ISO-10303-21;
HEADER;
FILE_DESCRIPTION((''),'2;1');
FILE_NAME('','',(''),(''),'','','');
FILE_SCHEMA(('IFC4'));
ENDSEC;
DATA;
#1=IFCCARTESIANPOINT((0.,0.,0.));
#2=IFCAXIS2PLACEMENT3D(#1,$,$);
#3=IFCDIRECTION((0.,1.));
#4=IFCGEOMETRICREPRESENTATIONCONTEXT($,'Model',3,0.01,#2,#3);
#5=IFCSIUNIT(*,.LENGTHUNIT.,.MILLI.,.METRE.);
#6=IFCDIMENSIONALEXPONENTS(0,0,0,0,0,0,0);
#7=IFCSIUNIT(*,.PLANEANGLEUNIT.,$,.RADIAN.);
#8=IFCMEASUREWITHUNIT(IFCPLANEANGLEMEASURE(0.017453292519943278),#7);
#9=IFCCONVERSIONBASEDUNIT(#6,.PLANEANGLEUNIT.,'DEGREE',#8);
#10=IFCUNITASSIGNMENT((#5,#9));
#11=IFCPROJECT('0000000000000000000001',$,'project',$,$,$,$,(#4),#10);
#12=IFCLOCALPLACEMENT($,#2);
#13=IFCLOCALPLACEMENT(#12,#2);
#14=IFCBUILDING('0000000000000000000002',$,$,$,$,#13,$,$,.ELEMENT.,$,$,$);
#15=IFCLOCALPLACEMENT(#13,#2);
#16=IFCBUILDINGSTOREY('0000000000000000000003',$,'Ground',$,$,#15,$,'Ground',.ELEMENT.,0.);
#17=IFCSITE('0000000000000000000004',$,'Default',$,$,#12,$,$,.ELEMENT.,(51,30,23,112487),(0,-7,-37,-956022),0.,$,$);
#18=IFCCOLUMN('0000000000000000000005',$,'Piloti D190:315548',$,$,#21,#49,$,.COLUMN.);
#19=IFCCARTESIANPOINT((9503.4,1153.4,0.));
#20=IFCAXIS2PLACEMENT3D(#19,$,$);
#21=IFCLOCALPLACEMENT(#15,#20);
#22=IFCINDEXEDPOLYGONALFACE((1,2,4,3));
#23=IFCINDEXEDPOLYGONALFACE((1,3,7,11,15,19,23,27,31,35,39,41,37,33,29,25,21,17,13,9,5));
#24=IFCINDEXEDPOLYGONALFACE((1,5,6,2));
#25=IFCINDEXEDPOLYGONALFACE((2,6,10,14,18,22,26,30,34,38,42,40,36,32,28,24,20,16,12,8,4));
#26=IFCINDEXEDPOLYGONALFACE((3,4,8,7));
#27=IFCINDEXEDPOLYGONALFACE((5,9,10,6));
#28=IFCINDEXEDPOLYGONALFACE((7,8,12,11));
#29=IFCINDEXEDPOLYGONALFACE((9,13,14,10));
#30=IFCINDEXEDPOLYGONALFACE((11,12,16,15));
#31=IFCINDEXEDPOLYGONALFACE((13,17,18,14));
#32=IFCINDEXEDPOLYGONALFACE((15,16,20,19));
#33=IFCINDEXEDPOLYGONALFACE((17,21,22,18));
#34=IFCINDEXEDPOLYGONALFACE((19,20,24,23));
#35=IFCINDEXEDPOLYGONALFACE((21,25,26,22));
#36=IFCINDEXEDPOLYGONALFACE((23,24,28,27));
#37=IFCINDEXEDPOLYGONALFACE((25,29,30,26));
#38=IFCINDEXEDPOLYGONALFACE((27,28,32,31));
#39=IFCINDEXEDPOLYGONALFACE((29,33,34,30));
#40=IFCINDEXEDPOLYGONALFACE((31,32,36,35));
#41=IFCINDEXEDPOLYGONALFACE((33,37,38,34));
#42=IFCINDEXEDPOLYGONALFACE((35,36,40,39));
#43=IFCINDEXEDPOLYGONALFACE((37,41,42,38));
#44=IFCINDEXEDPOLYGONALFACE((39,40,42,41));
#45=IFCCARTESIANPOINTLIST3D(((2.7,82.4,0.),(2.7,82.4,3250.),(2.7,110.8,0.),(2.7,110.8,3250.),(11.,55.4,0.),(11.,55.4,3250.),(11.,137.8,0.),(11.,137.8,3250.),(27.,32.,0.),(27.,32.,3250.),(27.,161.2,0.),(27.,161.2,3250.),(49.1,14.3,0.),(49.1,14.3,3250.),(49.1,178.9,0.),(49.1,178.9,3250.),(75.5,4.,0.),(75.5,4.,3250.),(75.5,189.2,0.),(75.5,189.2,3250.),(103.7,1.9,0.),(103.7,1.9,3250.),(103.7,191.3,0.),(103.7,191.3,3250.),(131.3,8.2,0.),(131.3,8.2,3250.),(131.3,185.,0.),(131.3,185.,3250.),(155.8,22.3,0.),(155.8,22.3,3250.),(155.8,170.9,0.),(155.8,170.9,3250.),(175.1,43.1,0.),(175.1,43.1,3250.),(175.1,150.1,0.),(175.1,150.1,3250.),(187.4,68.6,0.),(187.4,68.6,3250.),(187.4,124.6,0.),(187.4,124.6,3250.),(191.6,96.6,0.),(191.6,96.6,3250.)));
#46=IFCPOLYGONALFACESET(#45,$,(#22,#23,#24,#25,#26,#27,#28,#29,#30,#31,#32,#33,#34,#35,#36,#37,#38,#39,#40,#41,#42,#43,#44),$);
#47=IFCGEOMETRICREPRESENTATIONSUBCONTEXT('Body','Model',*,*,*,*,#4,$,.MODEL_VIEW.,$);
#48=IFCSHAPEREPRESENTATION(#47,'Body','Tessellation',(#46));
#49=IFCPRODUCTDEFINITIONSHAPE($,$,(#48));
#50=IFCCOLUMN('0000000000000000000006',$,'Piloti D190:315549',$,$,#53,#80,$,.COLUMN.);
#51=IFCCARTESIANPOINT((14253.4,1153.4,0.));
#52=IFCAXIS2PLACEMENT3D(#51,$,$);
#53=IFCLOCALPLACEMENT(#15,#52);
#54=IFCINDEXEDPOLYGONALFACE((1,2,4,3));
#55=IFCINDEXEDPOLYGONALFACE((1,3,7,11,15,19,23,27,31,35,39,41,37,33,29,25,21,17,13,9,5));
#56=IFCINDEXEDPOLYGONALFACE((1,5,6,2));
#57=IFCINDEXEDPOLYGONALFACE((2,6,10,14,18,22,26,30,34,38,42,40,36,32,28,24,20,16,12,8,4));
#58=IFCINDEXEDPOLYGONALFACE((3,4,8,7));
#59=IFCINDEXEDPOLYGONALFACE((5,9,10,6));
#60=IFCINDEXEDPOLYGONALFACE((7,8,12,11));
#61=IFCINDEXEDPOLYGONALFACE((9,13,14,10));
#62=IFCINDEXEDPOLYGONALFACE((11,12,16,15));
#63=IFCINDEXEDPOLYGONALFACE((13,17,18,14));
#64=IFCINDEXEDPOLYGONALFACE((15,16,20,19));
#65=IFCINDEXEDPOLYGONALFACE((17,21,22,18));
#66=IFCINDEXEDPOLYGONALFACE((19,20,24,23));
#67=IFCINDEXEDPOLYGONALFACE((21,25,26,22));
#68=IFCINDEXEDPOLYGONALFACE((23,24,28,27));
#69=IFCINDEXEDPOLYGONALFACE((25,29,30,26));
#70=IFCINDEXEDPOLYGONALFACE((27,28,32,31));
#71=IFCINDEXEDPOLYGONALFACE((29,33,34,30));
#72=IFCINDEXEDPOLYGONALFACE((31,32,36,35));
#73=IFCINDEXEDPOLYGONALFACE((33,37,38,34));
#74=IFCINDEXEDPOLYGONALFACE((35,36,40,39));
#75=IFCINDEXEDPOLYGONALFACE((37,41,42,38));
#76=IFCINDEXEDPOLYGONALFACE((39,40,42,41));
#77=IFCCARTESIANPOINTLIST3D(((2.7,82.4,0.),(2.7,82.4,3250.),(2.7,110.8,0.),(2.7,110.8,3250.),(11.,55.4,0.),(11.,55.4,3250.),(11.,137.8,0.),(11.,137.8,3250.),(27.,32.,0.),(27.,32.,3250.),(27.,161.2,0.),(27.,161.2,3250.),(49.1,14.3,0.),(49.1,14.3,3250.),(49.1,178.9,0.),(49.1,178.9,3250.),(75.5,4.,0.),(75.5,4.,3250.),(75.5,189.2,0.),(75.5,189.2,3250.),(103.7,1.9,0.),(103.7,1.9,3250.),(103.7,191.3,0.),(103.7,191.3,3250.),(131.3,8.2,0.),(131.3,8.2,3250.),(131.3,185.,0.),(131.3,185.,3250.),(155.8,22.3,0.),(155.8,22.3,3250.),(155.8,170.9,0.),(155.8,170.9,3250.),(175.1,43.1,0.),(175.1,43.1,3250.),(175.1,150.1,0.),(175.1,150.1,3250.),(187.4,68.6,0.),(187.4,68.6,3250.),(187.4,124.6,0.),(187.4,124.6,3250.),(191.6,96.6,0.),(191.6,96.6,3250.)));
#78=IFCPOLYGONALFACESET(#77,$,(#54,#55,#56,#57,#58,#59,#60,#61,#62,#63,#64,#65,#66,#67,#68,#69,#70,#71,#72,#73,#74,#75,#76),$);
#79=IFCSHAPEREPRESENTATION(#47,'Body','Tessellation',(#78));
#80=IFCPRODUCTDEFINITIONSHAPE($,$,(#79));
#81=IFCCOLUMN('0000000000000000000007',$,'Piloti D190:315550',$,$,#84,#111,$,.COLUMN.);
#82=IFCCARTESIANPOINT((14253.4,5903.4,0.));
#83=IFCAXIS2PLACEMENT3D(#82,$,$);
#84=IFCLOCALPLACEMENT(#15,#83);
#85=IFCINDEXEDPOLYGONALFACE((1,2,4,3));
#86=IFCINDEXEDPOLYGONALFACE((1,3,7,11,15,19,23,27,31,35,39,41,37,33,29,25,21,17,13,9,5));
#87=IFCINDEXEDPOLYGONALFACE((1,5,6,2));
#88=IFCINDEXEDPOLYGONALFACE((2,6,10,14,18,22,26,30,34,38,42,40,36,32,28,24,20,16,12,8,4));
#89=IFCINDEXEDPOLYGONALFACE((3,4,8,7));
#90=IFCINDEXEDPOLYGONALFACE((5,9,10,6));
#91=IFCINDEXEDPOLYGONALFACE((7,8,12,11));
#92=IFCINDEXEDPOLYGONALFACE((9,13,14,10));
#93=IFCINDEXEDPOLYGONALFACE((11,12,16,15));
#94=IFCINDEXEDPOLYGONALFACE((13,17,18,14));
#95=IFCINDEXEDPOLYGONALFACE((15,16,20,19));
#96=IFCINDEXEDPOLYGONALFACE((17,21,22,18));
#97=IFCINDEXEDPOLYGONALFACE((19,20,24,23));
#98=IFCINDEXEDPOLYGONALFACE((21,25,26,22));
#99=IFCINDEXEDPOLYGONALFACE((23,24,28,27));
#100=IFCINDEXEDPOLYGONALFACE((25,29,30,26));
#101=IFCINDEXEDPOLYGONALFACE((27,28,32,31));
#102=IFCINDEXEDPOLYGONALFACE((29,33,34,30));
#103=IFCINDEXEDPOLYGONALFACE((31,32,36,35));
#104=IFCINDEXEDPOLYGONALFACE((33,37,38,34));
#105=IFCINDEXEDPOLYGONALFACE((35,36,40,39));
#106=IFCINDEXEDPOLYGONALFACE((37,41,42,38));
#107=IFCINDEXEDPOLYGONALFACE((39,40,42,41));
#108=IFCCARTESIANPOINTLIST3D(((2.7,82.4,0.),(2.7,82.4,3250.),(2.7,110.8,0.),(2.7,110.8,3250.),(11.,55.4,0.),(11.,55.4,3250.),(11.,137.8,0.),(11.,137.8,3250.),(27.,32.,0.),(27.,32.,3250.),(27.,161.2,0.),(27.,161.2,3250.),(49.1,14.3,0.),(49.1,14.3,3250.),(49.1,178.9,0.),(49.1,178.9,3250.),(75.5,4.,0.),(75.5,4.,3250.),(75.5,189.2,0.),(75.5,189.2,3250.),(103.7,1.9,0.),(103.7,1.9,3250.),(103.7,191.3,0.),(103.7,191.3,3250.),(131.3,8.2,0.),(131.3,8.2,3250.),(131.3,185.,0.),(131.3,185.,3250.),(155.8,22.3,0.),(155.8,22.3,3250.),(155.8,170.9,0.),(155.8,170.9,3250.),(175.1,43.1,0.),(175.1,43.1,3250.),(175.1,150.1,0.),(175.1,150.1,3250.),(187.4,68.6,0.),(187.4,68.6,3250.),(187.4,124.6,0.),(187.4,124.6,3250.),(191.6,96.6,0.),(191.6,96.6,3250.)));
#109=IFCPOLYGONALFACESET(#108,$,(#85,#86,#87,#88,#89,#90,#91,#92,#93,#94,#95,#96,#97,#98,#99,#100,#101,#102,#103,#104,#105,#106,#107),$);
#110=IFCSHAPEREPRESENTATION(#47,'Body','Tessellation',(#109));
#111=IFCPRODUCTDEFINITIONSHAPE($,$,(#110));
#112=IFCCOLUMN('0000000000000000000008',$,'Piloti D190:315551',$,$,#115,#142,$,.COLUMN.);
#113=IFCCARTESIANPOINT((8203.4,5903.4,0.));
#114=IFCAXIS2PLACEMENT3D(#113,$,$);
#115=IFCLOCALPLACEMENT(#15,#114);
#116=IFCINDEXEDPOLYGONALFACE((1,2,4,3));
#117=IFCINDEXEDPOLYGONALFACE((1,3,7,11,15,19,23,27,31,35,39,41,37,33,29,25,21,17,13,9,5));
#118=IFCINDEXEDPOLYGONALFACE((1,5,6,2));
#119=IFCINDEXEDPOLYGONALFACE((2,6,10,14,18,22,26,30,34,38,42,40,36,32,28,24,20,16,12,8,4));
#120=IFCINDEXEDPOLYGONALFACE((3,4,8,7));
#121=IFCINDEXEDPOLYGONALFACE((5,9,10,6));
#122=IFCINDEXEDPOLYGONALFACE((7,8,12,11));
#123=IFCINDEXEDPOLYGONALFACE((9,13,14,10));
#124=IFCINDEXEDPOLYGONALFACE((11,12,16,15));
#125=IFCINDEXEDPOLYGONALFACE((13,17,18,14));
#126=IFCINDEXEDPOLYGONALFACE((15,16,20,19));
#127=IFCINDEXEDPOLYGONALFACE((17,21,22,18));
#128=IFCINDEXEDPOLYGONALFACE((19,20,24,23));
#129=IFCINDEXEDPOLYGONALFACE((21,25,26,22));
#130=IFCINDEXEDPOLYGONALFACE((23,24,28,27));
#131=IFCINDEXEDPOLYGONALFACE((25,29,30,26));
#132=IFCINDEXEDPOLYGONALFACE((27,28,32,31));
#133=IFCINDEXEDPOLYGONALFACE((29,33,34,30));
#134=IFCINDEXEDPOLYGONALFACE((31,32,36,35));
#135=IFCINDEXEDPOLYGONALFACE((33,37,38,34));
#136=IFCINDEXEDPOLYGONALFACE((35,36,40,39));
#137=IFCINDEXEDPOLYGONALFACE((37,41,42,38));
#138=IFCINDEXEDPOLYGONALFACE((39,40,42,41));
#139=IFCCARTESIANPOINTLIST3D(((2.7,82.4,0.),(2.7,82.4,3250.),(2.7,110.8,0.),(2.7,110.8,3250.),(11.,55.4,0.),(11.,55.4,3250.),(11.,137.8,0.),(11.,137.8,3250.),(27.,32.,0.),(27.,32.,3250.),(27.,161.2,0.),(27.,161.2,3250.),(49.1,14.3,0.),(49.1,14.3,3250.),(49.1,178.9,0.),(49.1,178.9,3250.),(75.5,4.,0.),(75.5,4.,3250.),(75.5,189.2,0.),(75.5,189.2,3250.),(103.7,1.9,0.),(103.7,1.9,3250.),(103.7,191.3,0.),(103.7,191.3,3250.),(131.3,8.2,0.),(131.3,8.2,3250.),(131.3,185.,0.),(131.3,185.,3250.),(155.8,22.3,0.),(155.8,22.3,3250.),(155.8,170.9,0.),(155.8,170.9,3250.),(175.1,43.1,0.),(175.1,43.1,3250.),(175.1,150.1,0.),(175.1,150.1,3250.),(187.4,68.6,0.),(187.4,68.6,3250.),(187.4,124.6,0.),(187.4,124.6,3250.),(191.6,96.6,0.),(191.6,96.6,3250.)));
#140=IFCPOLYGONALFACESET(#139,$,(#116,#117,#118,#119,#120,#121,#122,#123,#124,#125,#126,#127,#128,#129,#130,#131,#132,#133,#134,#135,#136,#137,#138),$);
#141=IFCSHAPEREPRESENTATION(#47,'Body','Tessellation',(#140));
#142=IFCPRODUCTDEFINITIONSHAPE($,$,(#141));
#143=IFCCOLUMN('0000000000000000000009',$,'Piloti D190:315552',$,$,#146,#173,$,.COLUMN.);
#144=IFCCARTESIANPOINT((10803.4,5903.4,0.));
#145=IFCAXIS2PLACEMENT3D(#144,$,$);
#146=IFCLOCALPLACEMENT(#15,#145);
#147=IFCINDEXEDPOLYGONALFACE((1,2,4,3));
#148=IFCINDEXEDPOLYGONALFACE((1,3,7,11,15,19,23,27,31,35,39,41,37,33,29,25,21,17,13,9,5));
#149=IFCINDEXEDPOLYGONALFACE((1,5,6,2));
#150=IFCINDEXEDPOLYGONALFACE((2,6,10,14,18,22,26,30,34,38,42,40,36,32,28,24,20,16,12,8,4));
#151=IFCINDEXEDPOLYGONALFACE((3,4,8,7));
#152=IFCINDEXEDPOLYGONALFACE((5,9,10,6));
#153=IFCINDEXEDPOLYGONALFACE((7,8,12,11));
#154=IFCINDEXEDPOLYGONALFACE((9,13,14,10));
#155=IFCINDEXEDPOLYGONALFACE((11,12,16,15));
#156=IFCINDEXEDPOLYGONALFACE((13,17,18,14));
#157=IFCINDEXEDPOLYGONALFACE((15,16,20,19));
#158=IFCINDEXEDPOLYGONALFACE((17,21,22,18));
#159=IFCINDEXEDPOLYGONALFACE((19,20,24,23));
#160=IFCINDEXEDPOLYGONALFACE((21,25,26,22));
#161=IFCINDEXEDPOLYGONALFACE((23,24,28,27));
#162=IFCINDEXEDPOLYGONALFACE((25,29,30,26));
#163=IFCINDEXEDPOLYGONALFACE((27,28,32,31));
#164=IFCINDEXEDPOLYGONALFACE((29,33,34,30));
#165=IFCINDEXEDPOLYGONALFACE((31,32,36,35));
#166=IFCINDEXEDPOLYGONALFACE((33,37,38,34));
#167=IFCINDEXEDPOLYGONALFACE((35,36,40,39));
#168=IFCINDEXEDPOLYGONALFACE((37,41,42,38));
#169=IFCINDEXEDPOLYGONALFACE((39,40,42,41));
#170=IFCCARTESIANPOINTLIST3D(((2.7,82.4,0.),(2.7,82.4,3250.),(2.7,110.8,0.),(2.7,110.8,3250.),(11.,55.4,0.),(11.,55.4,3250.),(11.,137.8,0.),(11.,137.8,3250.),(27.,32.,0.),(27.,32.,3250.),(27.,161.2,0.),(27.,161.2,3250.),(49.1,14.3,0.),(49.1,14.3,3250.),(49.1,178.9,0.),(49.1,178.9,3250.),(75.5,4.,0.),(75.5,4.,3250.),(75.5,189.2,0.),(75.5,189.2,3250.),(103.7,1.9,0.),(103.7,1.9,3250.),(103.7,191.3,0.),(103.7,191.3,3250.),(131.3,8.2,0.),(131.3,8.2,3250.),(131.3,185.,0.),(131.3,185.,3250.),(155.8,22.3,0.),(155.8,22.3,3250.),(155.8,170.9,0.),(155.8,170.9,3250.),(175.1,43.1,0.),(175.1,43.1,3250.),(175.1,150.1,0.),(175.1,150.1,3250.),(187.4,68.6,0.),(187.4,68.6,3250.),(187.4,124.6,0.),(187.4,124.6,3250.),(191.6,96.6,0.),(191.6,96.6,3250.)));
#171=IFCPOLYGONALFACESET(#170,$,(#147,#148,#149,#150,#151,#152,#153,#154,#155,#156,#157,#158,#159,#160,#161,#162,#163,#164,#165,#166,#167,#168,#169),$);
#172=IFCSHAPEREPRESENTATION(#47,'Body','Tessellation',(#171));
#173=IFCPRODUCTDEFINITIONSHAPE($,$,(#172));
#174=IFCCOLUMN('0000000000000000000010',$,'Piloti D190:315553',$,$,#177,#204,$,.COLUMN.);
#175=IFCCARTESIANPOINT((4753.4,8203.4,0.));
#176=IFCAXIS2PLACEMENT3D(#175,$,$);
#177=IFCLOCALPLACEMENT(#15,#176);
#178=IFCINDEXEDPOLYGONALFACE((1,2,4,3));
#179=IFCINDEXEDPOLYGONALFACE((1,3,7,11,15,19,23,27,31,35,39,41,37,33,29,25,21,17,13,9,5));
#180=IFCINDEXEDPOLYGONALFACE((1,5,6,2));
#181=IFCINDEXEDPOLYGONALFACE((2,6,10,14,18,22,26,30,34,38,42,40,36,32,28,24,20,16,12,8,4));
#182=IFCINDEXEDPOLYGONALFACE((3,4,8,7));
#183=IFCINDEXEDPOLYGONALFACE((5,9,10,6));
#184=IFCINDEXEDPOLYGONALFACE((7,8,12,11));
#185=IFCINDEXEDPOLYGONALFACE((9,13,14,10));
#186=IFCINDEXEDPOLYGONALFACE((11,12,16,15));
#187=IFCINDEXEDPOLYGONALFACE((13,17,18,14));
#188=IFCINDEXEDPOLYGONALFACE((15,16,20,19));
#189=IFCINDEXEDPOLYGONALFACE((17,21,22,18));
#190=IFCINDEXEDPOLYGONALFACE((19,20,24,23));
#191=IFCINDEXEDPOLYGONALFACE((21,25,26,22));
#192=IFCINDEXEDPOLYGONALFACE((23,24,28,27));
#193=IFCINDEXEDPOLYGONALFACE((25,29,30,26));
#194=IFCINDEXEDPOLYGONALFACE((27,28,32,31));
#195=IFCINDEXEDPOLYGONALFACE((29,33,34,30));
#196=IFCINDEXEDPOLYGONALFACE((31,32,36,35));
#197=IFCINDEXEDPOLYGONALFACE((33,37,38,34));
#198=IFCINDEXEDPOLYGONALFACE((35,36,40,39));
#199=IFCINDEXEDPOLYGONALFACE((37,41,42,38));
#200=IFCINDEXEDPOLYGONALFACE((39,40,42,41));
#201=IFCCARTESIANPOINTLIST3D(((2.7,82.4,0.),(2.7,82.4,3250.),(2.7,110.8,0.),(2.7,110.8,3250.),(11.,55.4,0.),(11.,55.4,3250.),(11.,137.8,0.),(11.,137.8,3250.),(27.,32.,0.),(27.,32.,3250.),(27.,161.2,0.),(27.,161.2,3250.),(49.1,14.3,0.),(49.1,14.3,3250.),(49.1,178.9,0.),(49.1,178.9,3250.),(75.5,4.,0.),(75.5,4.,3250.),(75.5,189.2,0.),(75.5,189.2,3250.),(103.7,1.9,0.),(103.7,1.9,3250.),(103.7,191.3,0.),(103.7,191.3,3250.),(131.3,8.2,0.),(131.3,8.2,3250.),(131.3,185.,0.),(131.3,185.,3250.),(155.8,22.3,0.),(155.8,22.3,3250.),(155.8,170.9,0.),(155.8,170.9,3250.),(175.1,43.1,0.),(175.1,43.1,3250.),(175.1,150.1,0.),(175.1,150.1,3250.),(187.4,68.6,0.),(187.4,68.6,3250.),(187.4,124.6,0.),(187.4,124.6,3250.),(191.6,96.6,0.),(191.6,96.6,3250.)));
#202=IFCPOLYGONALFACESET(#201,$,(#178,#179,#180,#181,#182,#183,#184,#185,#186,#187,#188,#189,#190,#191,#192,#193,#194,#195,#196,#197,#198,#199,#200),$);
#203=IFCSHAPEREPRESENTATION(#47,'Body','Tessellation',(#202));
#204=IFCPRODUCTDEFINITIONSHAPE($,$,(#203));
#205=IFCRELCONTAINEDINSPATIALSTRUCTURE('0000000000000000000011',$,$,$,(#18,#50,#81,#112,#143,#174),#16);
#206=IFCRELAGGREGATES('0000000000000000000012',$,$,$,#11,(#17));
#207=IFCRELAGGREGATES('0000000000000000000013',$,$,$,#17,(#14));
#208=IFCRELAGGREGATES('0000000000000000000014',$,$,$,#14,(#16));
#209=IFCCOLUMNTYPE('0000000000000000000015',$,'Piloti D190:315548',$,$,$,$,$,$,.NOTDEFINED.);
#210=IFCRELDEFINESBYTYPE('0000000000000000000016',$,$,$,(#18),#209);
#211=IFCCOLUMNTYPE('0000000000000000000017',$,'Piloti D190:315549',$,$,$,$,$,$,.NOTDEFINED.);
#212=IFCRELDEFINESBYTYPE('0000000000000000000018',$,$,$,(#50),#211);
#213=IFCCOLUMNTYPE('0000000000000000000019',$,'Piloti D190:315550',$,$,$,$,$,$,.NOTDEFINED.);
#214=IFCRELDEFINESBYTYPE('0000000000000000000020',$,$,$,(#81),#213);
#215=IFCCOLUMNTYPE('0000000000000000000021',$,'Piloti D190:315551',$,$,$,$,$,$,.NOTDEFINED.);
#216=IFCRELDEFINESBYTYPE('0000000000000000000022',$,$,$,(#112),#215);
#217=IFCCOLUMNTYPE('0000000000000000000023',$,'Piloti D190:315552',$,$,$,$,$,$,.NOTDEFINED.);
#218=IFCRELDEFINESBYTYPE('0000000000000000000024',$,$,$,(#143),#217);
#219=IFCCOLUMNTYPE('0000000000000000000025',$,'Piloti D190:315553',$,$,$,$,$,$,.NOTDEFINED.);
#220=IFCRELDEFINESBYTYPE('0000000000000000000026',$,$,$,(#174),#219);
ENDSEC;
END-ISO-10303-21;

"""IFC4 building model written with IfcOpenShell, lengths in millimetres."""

from ifc_helpers import new_model, entity, si_unit, converted_unit, direction, frame, origin, origin_2d_with_axis, place, context, subcontext, project, spatial, circle, extrude, type_object, element, save


model = new_model("IFC4")

# Units and contexts
model_context = context("Model", 3, precision=0.01, world=origin(), true_north=direction((0.0, 1.0)))
body_context = subcontext(model_context, "Body", "Model", "MODEL_VIEW")
ifc_project = project(units=[si_unit("LENGTHUNIT", "METRE", prefix="MILLI"), converted_unit("PLANEANGLEUNIT", "DEGREE", entity("IfcPlaneAngleMeasure", 0.017453292519943278), si_unit("PLANEANGLEUNIT", "RADIAN"), dimensions=[0, 0, 0, 0, 0, 0, 0])], contexts=[model_context])

# Site, building, storey
site_placement = place(None, origin())
site = spatial("IfcSite", under=ifc_project, at=site_placement, Name="Default", CompositionType="ELEMENT", RefLatitude=(51, 30, 23, 112487), RefLongitude=(0, -7, -37, -956022), RefElevation=0.0)
building_placement = place(site_placement, origin())
building = spatial("IfcBuilding", under=site, at=building_placement, CompositionType="ELEMENT")
storey_placement = place(building_placement, origin())
storey = spatial("IfcBuildingStorey", under=building, at=storey_placement, Name="Ground", LongName="Ground", CompositionType="ELEMENT", Elevation=0.0)

# Columns
column_type_1 = type_object("IfcColumnType", Name="Piloti D190:315548", PredefinedType="NOTDEFINED")
column_1_placement = place(storey_placement, frame((9503.4, 1153.4, 0.0)))
element("IfcColumn", 1, at=column_1_placement, inside=storey, type_object=column_type_1, Name="Piloti D190:315548", PredefinedType="COLUMN", context=body_context, shape_type="SweptSolid", body=[
    extrude(circle(Radius=95.0, at=origin_2d_with_axis()), frame((96.6, 96.6, 0.0)), (0.0, 0.0, 1.0), 3250.0),
])
column_type_2 = type_object("IfcColumnType", Name="Piloti D190:315549", PredefinedType="NOTDEFINED")
column_2_placement = place(storey_placement, frame((14253.4, 1153.4, 0.0)))
element("IfcColumn", 2, at=column_2_placement, inside=storey, type_object=column_type_2, Name="Piloti D190:315549", PredefinedType="COLUMN", context=body_context, shape_type="SweptSolid", body=[
    extrude(circle(Radius=95.0, at=origin_2d_with_axis()), frame((96.6, 96.6, 0.0)), (0.0, 0.0, 1.0), 3250.0),
])
column_type_3 = type_object("IfcColumnType", Name="Piloti D190:315550", PredefinedType="NOTDEFINED")
column_3_placement = place(storey_placement, frame((14253.4, 5903.4, 0.0)))
element("IfcColumn", 3, at=column_3_placement, inside=storey, type_object=column_type_3, Name="Piloti D190:315550", PredefinedType="COLUMN", context=body_context, shape_type="SweptSolid", body=[
    extrude(circle(Radius=95.0, at=origin_2d_with_axis()), frame((96.6, 96.6, 0.0)), (0.0, 0.0, 1.0), 3250.0),
])
column_type_4 = type_object("IfcColumnType", Name="Piloti D190:315551", PredefinedType="NOTDEFINED")
column_4_placement = place(storey_placement, frame((8203.4, 5903.4, 0.0)))
element("IfcColumn", 4, at=column_4_placement, inside=storey, type_object=column_type_4, Name="Piloti D190:315551", PredefinedType="COLUMN", context=body_context, shape_type="SweptSolid", body=[
    extrude(circle(Radius=95.0, at=origin_2d_with_axis()), frame((96.6, 96.6, 0.0)), (0.0, 0.0, 1.0), 3250.0),
])
column_type_5 = type_object("IfcColumnType", Name="Piloti D190:315552", PredefinedType="NOTDEFINED")
column_5_placement = place(storey_placement, frame((10803.4, 5903.4, 0.0)))
element("IfcColumn", 5, at=column_5_placement, inside=storey, type_object=column_type_5, Name="Piloti D190:315552", PredefinedType="COLUMN", context=body_context, shape_type="SweptSolid", body=[
    extrude(circle(Radius=95.0, at=origin_2d_with_axis()), frame((96.6, 96.6, 0.0)), (0.0, 0.0, 1.0), 3250.0),
])
column_type_6 = type_object("IfcColumnType", Name="Piloti D190:315553", PredefinedType="NOTDEFINED")
column_6_placement = place(storey_placement, frame((4753.4, 8203.4, 0.0)))
element("IfcColumn", 6, at=column_6_placement, inside=storey, type_object=column_type_6, Name="Piloti D190:315553", PredefinedType="COLUMN", context=body_context, shape_type="SweptSolid", body=[
    extrude(circle(Radius=95.0, at=origin_2d_with_axis()), frame((96.6, 96.6, 0.0)), (0.0, 0.0, 1.0), 3250.0),
])

save(model, "model.ifc")
